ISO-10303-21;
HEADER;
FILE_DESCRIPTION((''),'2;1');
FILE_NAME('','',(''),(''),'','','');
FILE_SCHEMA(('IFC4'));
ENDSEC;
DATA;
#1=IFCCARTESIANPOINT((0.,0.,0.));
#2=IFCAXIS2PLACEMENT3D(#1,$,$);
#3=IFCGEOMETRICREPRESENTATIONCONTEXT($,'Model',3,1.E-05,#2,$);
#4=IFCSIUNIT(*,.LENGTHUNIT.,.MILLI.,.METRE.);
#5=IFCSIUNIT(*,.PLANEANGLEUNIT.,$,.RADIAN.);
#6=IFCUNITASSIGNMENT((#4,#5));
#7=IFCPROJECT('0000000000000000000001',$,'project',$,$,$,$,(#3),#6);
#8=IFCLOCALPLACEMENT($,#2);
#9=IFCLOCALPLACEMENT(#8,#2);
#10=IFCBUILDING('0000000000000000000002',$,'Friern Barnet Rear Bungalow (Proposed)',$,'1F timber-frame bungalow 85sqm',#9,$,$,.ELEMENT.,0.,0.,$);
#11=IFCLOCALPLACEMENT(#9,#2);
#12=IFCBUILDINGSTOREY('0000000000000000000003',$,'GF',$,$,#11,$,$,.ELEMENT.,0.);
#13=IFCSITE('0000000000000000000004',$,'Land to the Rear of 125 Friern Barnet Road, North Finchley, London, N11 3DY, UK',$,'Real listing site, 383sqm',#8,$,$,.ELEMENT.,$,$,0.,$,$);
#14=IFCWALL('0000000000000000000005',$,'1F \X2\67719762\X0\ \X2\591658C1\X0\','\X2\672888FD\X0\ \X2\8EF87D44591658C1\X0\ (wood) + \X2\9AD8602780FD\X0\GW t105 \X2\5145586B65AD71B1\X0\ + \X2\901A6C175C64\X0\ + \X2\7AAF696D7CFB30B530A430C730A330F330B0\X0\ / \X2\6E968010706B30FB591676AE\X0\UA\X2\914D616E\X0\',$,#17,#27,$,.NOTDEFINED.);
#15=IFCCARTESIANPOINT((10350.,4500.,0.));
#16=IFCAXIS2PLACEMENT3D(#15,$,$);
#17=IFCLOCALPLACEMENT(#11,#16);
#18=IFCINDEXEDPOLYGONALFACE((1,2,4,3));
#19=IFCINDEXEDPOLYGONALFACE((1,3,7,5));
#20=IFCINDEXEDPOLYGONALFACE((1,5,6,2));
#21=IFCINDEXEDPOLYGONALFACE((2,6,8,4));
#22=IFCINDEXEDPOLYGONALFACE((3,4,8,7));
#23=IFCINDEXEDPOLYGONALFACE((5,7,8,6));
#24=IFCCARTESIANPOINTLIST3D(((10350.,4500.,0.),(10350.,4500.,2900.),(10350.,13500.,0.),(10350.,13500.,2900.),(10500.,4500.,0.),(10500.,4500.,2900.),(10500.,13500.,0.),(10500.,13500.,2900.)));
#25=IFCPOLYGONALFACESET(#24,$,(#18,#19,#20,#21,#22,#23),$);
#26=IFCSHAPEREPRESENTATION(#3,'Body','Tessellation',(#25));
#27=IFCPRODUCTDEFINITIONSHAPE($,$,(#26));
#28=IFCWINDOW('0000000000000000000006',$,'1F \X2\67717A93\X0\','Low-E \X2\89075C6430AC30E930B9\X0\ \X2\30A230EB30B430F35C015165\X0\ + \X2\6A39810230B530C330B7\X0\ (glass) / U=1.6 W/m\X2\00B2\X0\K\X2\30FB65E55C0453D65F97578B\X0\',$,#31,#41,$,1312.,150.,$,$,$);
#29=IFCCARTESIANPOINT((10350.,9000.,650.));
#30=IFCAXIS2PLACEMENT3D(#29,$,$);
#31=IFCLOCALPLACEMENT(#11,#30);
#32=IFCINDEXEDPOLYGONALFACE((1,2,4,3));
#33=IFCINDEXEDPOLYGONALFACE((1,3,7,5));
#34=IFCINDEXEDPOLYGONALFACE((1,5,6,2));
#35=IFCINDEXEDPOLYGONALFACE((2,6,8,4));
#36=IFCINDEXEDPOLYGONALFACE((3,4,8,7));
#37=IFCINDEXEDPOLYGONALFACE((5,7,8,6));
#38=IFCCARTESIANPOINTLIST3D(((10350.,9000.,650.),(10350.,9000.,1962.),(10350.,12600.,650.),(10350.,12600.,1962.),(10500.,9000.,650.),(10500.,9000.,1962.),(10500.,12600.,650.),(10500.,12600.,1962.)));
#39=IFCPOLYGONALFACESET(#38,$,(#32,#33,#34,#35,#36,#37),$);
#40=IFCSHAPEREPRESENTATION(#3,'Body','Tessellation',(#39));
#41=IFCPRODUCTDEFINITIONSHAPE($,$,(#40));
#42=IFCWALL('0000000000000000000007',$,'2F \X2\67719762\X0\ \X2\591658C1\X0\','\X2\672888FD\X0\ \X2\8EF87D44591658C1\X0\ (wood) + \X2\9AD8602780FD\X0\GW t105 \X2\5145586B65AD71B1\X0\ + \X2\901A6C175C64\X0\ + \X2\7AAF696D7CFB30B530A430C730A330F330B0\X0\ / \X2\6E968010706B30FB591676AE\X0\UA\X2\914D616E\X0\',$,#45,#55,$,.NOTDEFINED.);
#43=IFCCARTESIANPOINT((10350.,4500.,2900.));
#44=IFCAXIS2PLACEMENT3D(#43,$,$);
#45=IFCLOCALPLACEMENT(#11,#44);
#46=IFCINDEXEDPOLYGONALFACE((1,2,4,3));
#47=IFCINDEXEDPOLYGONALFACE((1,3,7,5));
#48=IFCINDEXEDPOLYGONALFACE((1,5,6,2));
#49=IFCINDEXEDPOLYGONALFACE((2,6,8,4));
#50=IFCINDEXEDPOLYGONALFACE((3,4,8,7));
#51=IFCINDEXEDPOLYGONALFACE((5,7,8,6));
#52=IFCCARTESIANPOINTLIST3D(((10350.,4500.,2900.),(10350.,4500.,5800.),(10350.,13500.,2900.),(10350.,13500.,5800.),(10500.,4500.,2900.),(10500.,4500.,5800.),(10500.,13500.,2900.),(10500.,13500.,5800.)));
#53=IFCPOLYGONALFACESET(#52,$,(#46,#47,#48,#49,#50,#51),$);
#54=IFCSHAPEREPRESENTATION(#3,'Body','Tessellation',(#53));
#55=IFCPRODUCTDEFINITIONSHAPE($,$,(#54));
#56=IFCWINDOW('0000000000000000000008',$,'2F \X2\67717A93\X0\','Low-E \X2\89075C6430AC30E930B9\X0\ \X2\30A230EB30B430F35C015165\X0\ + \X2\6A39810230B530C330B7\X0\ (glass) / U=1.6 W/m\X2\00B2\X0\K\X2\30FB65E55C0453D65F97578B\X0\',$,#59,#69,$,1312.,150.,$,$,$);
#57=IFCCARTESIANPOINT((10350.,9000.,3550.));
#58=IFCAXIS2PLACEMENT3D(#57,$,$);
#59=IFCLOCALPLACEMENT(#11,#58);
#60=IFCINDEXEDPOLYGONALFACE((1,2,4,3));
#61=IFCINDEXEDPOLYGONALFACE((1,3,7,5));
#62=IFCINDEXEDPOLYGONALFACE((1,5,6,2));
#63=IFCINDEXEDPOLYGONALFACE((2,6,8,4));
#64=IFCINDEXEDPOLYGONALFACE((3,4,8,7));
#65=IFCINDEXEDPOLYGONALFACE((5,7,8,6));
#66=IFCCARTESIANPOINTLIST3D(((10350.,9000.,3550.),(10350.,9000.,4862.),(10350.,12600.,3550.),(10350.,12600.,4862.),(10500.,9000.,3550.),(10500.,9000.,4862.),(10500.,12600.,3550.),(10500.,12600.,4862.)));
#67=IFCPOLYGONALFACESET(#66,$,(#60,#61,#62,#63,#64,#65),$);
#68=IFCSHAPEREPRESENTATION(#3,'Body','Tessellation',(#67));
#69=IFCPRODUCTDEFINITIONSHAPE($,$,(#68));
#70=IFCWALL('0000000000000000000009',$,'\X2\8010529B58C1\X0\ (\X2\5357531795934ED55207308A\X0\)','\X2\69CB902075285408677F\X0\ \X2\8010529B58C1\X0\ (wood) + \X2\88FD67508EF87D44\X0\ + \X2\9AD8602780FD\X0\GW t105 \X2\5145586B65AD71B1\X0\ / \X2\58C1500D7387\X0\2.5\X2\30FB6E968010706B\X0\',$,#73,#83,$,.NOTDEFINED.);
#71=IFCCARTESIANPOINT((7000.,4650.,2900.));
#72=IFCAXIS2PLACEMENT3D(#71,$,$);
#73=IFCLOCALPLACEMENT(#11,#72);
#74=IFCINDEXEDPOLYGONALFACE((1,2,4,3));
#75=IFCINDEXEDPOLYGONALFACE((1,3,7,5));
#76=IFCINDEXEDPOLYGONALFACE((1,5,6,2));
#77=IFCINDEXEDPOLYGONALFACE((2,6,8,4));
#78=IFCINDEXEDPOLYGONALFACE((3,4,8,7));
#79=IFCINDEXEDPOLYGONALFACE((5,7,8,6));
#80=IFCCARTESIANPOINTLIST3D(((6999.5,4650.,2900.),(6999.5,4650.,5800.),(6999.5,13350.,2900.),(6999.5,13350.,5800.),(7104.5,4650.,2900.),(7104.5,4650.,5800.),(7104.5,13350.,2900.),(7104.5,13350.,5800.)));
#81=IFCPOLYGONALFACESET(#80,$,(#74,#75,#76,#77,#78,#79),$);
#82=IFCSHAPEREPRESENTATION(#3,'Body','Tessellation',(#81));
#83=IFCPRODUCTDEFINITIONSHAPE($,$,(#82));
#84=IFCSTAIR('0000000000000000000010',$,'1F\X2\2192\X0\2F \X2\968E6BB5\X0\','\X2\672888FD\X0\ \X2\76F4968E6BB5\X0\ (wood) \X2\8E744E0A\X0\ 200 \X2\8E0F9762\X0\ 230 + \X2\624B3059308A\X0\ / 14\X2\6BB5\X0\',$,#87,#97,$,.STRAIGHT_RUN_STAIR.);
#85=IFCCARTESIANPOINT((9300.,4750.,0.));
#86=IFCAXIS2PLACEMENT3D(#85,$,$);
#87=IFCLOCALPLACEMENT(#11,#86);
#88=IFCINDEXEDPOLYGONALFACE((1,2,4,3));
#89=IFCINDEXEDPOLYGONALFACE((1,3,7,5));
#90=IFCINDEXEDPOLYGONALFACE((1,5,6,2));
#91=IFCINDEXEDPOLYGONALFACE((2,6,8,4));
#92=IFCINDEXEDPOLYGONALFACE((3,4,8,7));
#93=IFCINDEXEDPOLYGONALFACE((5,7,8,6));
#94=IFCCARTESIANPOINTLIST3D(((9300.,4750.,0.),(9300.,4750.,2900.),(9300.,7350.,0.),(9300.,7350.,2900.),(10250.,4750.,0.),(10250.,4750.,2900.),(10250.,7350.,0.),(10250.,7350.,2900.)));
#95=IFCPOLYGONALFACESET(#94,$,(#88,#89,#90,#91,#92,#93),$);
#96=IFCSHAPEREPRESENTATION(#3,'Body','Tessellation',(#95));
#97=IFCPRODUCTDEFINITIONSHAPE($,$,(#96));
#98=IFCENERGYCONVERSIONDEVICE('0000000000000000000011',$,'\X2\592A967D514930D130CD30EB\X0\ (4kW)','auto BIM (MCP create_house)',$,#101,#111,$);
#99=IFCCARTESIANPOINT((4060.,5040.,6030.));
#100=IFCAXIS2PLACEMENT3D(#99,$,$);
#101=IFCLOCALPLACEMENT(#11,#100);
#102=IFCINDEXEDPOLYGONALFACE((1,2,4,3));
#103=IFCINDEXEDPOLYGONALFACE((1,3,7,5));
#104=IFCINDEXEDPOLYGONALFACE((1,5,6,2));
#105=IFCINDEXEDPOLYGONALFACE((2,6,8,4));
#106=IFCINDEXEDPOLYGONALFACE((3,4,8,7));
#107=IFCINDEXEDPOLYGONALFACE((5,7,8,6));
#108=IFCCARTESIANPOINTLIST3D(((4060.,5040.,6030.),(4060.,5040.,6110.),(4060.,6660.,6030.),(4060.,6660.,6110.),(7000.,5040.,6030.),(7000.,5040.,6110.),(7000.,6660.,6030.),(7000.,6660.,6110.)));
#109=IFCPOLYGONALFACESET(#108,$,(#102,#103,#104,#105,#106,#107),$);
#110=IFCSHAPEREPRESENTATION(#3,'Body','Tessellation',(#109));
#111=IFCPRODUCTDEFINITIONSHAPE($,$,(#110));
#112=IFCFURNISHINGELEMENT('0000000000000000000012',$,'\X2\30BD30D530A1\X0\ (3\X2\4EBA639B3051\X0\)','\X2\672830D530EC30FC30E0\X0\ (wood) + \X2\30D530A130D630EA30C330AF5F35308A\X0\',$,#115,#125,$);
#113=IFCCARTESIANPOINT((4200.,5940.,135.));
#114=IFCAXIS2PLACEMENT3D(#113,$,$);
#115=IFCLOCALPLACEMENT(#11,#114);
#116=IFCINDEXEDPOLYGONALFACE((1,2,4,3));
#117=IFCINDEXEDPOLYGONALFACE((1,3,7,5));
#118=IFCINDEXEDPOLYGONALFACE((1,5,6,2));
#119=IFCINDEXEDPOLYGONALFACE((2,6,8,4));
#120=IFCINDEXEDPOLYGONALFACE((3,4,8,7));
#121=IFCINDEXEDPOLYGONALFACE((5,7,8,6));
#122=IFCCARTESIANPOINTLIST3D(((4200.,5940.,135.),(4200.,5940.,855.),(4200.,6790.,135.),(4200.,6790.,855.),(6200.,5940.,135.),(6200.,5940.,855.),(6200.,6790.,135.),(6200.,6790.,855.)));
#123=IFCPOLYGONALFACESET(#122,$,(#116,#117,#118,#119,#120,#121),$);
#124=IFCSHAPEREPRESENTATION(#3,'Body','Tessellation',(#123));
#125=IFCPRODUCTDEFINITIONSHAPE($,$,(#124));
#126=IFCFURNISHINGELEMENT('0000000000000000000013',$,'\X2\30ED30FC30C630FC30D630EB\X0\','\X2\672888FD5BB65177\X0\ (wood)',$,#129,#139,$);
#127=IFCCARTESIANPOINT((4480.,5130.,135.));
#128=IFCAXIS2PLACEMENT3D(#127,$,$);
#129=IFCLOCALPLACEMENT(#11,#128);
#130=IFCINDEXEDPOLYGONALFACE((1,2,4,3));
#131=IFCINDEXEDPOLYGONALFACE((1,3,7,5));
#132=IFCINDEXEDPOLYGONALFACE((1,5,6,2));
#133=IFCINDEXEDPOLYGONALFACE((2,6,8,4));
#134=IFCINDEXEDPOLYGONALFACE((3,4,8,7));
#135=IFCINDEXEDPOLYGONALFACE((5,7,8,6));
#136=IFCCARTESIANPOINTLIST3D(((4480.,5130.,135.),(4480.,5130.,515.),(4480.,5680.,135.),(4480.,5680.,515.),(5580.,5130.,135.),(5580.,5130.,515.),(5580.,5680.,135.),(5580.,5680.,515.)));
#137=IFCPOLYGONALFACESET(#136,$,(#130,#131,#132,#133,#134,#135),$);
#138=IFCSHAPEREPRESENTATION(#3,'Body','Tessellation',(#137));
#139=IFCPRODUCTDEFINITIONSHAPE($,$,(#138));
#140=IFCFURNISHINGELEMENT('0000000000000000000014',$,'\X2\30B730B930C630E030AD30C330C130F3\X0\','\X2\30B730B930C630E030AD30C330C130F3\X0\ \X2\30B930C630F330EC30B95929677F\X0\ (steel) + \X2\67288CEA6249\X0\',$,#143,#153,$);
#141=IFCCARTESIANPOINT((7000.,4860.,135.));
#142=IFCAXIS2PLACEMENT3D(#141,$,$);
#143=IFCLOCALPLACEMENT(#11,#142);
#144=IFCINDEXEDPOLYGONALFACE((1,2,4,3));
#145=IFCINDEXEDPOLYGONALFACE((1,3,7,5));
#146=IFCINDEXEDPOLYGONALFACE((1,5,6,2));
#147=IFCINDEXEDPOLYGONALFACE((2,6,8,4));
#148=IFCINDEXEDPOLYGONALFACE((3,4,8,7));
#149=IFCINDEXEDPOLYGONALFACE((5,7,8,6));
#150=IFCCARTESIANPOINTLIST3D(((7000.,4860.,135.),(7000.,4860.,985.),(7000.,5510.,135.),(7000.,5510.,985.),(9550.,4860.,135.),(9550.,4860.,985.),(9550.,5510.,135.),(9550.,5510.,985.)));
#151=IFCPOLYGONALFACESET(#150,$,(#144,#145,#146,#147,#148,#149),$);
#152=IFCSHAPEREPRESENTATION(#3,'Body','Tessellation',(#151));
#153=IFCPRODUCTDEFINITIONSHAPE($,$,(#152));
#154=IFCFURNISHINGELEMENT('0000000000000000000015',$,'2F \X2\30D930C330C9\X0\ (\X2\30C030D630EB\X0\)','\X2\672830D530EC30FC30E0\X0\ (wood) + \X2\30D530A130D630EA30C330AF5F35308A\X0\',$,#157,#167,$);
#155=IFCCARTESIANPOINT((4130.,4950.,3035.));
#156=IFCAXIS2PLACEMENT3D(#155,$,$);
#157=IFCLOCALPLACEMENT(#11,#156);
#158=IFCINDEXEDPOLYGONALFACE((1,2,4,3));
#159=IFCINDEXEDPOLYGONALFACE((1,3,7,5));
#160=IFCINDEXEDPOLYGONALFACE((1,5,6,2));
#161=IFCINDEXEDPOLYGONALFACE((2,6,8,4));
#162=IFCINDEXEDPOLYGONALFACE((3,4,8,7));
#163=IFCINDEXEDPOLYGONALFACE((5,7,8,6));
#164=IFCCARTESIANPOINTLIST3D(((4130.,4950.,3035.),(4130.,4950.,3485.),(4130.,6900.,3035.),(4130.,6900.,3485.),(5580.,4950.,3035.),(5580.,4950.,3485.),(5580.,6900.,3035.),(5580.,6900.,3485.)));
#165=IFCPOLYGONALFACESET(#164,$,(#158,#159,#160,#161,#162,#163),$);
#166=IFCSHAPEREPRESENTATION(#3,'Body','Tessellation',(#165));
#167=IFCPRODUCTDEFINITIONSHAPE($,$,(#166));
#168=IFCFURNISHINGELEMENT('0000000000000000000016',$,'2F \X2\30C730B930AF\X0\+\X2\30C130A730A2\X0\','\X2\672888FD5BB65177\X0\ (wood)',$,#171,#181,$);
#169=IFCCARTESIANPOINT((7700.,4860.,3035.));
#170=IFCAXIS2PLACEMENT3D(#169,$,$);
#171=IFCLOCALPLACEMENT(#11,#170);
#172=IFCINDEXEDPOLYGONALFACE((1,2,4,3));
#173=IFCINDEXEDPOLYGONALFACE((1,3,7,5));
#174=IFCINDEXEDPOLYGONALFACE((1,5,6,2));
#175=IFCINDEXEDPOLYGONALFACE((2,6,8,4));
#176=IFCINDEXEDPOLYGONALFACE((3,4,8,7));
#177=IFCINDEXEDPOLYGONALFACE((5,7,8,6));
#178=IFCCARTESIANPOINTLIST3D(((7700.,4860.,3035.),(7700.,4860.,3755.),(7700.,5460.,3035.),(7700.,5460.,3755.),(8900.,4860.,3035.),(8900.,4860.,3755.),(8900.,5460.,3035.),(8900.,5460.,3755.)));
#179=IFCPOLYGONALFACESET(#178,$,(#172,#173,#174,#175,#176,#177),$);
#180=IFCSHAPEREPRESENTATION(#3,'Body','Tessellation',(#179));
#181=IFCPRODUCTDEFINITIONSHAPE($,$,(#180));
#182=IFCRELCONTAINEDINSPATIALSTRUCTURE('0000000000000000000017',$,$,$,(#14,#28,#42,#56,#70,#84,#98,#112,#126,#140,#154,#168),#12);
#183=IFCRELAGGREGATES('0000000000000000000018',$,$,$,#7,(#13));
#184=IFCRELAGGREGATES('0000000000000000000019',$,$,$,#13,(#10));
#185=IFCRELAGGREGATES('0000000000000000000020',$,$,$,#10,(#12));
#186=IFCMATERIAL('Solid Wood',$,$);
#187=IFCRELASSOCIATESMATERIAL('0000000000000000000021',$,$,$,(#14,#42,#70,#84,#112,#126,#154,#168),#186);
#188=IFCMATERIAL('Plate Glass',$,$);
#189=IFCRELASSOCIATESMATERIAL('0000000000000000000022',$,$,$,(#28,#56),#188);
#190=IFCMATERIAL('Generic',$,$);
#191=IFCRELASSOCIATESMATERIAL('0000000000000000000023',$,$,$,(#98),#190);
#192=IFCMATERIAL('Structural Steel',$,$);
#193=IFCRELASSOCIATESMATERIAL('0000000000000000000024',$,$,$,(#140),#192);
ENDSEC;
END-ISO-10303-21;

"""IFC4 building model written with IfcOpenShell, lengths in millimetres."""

from ifc_helpers import new_model, si_unit, frame, frame_2d, origin, place, context, project, spatial, rectangle, extrude, material, element, fill, save


model = new_model("IFC4")

# Units and contexts
model_context = context("Model", 3, precision=1e-05, world=origin())
ifc_project = project(units=[si_unit("LENGTHUNIT", "METRE", prefix="MILLI"), si_unit("PLANEANGLEUNIT", "RADIAN")], contexts=[model_context])

# Site, building, storey
site_placement = place(None, origin())
site = spatial("IfcSite", under=ifc_project, at=site_placement, Name="Land to the Rear of 125 Friern Barnet Road, North Finchley, London, N11 3DY, UK", ObjectType="Real listing site, 383sqm", CompositionType="ELEMENT", RefElevation=0.0)
building_placement = place(site_placement, origin())
building = spatial("IfcBuilding", under=site, at=building_placement, Name="Friern Barnet Rear Bungalow (Proposed)", ObjectType="1F timber-frame bungalow 85sqm", CompositionType="ELEMENT", ElevationOfRefHeight=0.0, ElevationOfTerrain=0.0)
storey_placement = place(building_placement, origin())
storey = spatial("IfcBuildingStorey", under=building, at=storey_placement, Name="GF", CompositionType="ELEMENT", Elevation=0.0)

# Wall, opening, window
ifc_material_1 = material(Name="Solid Wood")
wall_1_placement = place(storey_placement, frame((10350.0, 4500.0, 0.0)))
wall_1 = element("IfcWall", 1, at=wall_1_placement, inside=storey, material=ifc_material_1, Name="1F 東面 外壁", Description="木製 軸組外壁 (wood) + 高性能GW t105 充填断熱 + 通気層 + 窯業系サイディング / 準耐火・外皮UA配慮", PredefinedType="NOTDEFINED", context=model_context, shape_type="SweptSolid", body=[
    extrude(rectangle(XDim=150.0, YDim=9000.0, at=frame_2d((75.0, 4500.0))), frame((10350.0, 4500.0, 0.0)), (0.0, 0.0, 1.0), 2900.0),
])
opening_1_placement = place(storey_placement, frame((10350.0, 9000.0, 650.0)))
opening_1 = element("IfcOpeningElement", 2, at=opening_1_placement, cuts=wall_1, PredefinedType="NOTDEFINED", context=model_context, shape_type="SweptSolid", body=[
    extrude(rectangle(XDim=150.0, YDim=3600.0, at=frame_2d((75.0, 1800.0))), frame((10350.0, 9000.0, 650.0)), (0.0, 0.0, 1.0), 1312.0),
])
ifc_material_2 = material(Name="Plate Glass")
window_1_placement = place(storey_placement, frame((10350.0, 9000.0, 650.0)))
window_1 = element("IfcWindow", 3, at=window_1_placement, inside=storey, material=ifc_material_2, Name="1F 東窓", Description="Low-E 複層ガラス アルゴン封入 + 樹脂サッシ (glass) / U=1.6 W/m²K・日射取得型", OverallHeight=1312.0, OverallWidth=150.0, context=model_context, shape_type="SweptSolid", body=[
    extrude(rectangle(XDim=150.0, YDim=3600.0, at=frame_2d((75.0, 1800.0))), frame((10350.0, 9000.0, 650.0)), (0.0, 0.0, 1.0), 1312.0),
])
fill(opening_1, window_1)

# Wall, opening, window
wall_2_placement = place(storey_placement, frame((10350.0, 4500.0, 2900.0)))
wall_2 = element("IfcWall", 4, at=wall_2_placement, inside=storey, material=ifc_material_1, Name="2F 東面 外壁", Description="木製 軸組外壁 (wood) + 高性能GW t105 充填断熱 + 通気層 + 窯業系サイディング / 準耐火・外皮UA配慮", PredefinedType="NOTDEFINED", context=model_context, shape_type="SweptSolid", body=[
    extrude(rectangle(XDim=150.0, YDim=9000.0, at=frame_2d((75.0, 4500.0))), frame((10350.0, 4500.0, 2900.0)), (0.0, 0.0, 1.0), 2900.0),
])
opening_2_placement = place(storey_placement, frame((10350.0, 9000.0, 3550.0)))
opening_2 = element("IfcOpeningElement", 5, at=opening_2_placement, cuts=wall_2, PredefinedType="NOTDEFINED", context=model_context, shape_type="SweptSolid", body=[
    extrude(rectangle(XDim=150.0, YDim=3600.0, at=frame_2d((75.0, 1800.0))), frame((10350.0, 9000.0, 3550.0)), (0.0, 0.0, 1.0), 1312.0),
])
window_2_placement = place(storey_placement, frame((10350.0, 9000.0, 3550.0)))
window_2 = element("IfcWindow", 6, at=window_2_placement, inside=storey, material=ifc_material_2, Name="2F 東窓", Description="Low-E 複層ガラス アルゴン封入 + 樹脂サッシ (glass) / U=1.6 W/m²K・日射取得型", OverallHeight=1312.0, OverallWidth=150.0, context=model_context, shape_type="SweptSolid", body=[
    extrude(rectangle(XDim=150.0, YDim=3600.0, at=frame_2d((75.0, 1800.0))), frame((10350.0, 9000.0, 3550.0)), (0.0, 0.0, 1.0), 1312.0),
])
fill(opening_2, window_2)

# Wall
wall_3_placement = place(storey_placement, frame((7000.0, 4650.0, 2900.0)))
element("IfcWall", 7, at=wall_3_placement, inside=storey, material=ifc_material_1, Name="耐力壁 (南北間仕切り)", Description="構造用合板 耐力壁 (wood) + 製材軸組 + 高性能GW t105 充填断熱 / 壁倍率2.5・準耐火", PredefinedType="NOTDEFINED", context=model_context, shape_type="SweptSolid", body=[
    extrude(rectangle(XDim=105.0, YDim=8700.0, at=frame_2d((52.0, 4350.0))), frame((7000.0, 4650.0, 2900.0)), (0.0, 0.0, 1.0), 2900.0),
])

# Stair
stair_placement = place(storey_placement, frame((9300.0, 4750.0, 0.0)))
element("IfcStair", 8, at=stair_placement, inside=storey, material=ifc_material_1, Name="1F→2F 階段", Description="木製 直階段 (wood) 蹴上 200 踏面 230 + 手すり / 14段", PredefinedType="STRAIGHT_RUN_STAIR", context=model_context, shape_type="SweptSolid", body=[
    extrude(rectangle(XDim=950.0, YDim=2600.0, at=frame_2d((475.0, 1300.0))), frame((9300.0, 4750.0, 0.0)), (0.0, 0.0, 1.0), 2900.0),
])

# Energy conversion device
ifc_material_3 = material(Name="Generic")
energy_conversion_device_placement = place(storey_placement, frame((4060.0, 5040.0, 6030.0)))
element("IfcEnergyConversionDevice", 9, at=energy_conversion_device_placement, inside=storey, material=ifc_material_3, Name="太陽光パネル (4kW)", Description="auto BIM (MCP create_house)", context=model_context, shape_type="SweptSolid", body=[
    extrude(rectangle(XDim=2940.0, YDim=1620.0, at=frame_2d((1470.0, 810.0))), frame((4060.0, 5040.0, 6030.0)), (0.0, 0.0, 1.0), 80.0),
])

# Furnishing elements
furnishing_1_placement = place(storey_placement, frame((4200.0, 5940.0, 135.0)))
element("IfcFurnishingElement", 10, at=furnishing_1_placement, inside=storey, material=ifc_material_1, Name="ソファ (3人掛け)", Description="木フレーム (wood) + ファブリック張り", context=model_context, shape_type="SweptSolid", body=[
    extrude(rectangle(XDim=2000.0, YDim=850.0, at=frame_2d((1000.0, 425.0))), frame((4200.0, 5940.0, 135.0)), (0.0, 0.0, 1.0), 720.0),
])
furnishing_2_placement = place(storey_placement, frame((4480.0, 5130.0, 135.0)))
element("IfcFurnishingElement", 11, at=furnishing_2_placement, inside=storey, material=ifc_material_1, Name="ローテーブル", Description="木製家具 (wood)", context=model_context, shape_type="SweptSolid", body=[
    extrude(rectangle(XDim=1100.0, YDim=550.0, at=frame_2d((550.0, 275.0))), frame((4480.0, 5130.0, 135.0)), (0.0, 0.0, 1.0), 380.0),
])
ifc_material_4 = material(Name="Structural Steel")
furnishing_3_placement = place(storey_placement, frame((7000.0, 4860.0, 135.0)))
element("IfcFurnishingElement", 12, at=furnishing_3_placement, inside=storey, material=ifc_material_4, Name="システムキッチン", Description="システムキッチン ステンレス天板 (steel) + 木質扉", context=model_context, shape_type="SweptSolid", body=[
    extrude(rectangle(XDim=2550.0, YDim=650.0, at=frame_2d((1275.0, 325.0))), frame((7000.0, 4860.0, 135.0)), (0.0, 0.0, 1.0), 850.0),
])
furnishing_4_placement = place(storey_placement, frame((4130.0, 4950.0, 3035.0)))
element("IfcFurnishingElement", 13, at=furnishing_4_placement, inside=storey, material=ifc_material_1, Name="2F ベッド (ダブル)", Description="木フレーム (wood) + ファブリック張り", context=model_context, shape_type="SweptSolid", body=[
    extrude(rectangle(XDim=1450.0, YDim=1950.0, at=frame_2d((725.0, 975.0))), frame((4130.0, 4950.0, 3035.0)), (0.0, 0.0, 1.0), 450.0),
])
furnishing_5_placement = place(storey_placement, frame((7700.0, 4860.0, 3035.0)))
element("IfcFurnishingElement", 14, at=furnishing_5_placement, inside=storey, material=ifc_material_1, Name="2F デスク+チェア", Description="木製家具 (wood)", context=model_context, shape_type="SweptSolid", body=[
    extrude(rectangle(XDim=1200.0, YDim=600.0, at=frame_2d((600.0, 300.0))), frame((7700.0, 4860.0, 3035.0)), (0.0, 0.0, 1.0), 720.0),
])

save(model, "model.ifc")
